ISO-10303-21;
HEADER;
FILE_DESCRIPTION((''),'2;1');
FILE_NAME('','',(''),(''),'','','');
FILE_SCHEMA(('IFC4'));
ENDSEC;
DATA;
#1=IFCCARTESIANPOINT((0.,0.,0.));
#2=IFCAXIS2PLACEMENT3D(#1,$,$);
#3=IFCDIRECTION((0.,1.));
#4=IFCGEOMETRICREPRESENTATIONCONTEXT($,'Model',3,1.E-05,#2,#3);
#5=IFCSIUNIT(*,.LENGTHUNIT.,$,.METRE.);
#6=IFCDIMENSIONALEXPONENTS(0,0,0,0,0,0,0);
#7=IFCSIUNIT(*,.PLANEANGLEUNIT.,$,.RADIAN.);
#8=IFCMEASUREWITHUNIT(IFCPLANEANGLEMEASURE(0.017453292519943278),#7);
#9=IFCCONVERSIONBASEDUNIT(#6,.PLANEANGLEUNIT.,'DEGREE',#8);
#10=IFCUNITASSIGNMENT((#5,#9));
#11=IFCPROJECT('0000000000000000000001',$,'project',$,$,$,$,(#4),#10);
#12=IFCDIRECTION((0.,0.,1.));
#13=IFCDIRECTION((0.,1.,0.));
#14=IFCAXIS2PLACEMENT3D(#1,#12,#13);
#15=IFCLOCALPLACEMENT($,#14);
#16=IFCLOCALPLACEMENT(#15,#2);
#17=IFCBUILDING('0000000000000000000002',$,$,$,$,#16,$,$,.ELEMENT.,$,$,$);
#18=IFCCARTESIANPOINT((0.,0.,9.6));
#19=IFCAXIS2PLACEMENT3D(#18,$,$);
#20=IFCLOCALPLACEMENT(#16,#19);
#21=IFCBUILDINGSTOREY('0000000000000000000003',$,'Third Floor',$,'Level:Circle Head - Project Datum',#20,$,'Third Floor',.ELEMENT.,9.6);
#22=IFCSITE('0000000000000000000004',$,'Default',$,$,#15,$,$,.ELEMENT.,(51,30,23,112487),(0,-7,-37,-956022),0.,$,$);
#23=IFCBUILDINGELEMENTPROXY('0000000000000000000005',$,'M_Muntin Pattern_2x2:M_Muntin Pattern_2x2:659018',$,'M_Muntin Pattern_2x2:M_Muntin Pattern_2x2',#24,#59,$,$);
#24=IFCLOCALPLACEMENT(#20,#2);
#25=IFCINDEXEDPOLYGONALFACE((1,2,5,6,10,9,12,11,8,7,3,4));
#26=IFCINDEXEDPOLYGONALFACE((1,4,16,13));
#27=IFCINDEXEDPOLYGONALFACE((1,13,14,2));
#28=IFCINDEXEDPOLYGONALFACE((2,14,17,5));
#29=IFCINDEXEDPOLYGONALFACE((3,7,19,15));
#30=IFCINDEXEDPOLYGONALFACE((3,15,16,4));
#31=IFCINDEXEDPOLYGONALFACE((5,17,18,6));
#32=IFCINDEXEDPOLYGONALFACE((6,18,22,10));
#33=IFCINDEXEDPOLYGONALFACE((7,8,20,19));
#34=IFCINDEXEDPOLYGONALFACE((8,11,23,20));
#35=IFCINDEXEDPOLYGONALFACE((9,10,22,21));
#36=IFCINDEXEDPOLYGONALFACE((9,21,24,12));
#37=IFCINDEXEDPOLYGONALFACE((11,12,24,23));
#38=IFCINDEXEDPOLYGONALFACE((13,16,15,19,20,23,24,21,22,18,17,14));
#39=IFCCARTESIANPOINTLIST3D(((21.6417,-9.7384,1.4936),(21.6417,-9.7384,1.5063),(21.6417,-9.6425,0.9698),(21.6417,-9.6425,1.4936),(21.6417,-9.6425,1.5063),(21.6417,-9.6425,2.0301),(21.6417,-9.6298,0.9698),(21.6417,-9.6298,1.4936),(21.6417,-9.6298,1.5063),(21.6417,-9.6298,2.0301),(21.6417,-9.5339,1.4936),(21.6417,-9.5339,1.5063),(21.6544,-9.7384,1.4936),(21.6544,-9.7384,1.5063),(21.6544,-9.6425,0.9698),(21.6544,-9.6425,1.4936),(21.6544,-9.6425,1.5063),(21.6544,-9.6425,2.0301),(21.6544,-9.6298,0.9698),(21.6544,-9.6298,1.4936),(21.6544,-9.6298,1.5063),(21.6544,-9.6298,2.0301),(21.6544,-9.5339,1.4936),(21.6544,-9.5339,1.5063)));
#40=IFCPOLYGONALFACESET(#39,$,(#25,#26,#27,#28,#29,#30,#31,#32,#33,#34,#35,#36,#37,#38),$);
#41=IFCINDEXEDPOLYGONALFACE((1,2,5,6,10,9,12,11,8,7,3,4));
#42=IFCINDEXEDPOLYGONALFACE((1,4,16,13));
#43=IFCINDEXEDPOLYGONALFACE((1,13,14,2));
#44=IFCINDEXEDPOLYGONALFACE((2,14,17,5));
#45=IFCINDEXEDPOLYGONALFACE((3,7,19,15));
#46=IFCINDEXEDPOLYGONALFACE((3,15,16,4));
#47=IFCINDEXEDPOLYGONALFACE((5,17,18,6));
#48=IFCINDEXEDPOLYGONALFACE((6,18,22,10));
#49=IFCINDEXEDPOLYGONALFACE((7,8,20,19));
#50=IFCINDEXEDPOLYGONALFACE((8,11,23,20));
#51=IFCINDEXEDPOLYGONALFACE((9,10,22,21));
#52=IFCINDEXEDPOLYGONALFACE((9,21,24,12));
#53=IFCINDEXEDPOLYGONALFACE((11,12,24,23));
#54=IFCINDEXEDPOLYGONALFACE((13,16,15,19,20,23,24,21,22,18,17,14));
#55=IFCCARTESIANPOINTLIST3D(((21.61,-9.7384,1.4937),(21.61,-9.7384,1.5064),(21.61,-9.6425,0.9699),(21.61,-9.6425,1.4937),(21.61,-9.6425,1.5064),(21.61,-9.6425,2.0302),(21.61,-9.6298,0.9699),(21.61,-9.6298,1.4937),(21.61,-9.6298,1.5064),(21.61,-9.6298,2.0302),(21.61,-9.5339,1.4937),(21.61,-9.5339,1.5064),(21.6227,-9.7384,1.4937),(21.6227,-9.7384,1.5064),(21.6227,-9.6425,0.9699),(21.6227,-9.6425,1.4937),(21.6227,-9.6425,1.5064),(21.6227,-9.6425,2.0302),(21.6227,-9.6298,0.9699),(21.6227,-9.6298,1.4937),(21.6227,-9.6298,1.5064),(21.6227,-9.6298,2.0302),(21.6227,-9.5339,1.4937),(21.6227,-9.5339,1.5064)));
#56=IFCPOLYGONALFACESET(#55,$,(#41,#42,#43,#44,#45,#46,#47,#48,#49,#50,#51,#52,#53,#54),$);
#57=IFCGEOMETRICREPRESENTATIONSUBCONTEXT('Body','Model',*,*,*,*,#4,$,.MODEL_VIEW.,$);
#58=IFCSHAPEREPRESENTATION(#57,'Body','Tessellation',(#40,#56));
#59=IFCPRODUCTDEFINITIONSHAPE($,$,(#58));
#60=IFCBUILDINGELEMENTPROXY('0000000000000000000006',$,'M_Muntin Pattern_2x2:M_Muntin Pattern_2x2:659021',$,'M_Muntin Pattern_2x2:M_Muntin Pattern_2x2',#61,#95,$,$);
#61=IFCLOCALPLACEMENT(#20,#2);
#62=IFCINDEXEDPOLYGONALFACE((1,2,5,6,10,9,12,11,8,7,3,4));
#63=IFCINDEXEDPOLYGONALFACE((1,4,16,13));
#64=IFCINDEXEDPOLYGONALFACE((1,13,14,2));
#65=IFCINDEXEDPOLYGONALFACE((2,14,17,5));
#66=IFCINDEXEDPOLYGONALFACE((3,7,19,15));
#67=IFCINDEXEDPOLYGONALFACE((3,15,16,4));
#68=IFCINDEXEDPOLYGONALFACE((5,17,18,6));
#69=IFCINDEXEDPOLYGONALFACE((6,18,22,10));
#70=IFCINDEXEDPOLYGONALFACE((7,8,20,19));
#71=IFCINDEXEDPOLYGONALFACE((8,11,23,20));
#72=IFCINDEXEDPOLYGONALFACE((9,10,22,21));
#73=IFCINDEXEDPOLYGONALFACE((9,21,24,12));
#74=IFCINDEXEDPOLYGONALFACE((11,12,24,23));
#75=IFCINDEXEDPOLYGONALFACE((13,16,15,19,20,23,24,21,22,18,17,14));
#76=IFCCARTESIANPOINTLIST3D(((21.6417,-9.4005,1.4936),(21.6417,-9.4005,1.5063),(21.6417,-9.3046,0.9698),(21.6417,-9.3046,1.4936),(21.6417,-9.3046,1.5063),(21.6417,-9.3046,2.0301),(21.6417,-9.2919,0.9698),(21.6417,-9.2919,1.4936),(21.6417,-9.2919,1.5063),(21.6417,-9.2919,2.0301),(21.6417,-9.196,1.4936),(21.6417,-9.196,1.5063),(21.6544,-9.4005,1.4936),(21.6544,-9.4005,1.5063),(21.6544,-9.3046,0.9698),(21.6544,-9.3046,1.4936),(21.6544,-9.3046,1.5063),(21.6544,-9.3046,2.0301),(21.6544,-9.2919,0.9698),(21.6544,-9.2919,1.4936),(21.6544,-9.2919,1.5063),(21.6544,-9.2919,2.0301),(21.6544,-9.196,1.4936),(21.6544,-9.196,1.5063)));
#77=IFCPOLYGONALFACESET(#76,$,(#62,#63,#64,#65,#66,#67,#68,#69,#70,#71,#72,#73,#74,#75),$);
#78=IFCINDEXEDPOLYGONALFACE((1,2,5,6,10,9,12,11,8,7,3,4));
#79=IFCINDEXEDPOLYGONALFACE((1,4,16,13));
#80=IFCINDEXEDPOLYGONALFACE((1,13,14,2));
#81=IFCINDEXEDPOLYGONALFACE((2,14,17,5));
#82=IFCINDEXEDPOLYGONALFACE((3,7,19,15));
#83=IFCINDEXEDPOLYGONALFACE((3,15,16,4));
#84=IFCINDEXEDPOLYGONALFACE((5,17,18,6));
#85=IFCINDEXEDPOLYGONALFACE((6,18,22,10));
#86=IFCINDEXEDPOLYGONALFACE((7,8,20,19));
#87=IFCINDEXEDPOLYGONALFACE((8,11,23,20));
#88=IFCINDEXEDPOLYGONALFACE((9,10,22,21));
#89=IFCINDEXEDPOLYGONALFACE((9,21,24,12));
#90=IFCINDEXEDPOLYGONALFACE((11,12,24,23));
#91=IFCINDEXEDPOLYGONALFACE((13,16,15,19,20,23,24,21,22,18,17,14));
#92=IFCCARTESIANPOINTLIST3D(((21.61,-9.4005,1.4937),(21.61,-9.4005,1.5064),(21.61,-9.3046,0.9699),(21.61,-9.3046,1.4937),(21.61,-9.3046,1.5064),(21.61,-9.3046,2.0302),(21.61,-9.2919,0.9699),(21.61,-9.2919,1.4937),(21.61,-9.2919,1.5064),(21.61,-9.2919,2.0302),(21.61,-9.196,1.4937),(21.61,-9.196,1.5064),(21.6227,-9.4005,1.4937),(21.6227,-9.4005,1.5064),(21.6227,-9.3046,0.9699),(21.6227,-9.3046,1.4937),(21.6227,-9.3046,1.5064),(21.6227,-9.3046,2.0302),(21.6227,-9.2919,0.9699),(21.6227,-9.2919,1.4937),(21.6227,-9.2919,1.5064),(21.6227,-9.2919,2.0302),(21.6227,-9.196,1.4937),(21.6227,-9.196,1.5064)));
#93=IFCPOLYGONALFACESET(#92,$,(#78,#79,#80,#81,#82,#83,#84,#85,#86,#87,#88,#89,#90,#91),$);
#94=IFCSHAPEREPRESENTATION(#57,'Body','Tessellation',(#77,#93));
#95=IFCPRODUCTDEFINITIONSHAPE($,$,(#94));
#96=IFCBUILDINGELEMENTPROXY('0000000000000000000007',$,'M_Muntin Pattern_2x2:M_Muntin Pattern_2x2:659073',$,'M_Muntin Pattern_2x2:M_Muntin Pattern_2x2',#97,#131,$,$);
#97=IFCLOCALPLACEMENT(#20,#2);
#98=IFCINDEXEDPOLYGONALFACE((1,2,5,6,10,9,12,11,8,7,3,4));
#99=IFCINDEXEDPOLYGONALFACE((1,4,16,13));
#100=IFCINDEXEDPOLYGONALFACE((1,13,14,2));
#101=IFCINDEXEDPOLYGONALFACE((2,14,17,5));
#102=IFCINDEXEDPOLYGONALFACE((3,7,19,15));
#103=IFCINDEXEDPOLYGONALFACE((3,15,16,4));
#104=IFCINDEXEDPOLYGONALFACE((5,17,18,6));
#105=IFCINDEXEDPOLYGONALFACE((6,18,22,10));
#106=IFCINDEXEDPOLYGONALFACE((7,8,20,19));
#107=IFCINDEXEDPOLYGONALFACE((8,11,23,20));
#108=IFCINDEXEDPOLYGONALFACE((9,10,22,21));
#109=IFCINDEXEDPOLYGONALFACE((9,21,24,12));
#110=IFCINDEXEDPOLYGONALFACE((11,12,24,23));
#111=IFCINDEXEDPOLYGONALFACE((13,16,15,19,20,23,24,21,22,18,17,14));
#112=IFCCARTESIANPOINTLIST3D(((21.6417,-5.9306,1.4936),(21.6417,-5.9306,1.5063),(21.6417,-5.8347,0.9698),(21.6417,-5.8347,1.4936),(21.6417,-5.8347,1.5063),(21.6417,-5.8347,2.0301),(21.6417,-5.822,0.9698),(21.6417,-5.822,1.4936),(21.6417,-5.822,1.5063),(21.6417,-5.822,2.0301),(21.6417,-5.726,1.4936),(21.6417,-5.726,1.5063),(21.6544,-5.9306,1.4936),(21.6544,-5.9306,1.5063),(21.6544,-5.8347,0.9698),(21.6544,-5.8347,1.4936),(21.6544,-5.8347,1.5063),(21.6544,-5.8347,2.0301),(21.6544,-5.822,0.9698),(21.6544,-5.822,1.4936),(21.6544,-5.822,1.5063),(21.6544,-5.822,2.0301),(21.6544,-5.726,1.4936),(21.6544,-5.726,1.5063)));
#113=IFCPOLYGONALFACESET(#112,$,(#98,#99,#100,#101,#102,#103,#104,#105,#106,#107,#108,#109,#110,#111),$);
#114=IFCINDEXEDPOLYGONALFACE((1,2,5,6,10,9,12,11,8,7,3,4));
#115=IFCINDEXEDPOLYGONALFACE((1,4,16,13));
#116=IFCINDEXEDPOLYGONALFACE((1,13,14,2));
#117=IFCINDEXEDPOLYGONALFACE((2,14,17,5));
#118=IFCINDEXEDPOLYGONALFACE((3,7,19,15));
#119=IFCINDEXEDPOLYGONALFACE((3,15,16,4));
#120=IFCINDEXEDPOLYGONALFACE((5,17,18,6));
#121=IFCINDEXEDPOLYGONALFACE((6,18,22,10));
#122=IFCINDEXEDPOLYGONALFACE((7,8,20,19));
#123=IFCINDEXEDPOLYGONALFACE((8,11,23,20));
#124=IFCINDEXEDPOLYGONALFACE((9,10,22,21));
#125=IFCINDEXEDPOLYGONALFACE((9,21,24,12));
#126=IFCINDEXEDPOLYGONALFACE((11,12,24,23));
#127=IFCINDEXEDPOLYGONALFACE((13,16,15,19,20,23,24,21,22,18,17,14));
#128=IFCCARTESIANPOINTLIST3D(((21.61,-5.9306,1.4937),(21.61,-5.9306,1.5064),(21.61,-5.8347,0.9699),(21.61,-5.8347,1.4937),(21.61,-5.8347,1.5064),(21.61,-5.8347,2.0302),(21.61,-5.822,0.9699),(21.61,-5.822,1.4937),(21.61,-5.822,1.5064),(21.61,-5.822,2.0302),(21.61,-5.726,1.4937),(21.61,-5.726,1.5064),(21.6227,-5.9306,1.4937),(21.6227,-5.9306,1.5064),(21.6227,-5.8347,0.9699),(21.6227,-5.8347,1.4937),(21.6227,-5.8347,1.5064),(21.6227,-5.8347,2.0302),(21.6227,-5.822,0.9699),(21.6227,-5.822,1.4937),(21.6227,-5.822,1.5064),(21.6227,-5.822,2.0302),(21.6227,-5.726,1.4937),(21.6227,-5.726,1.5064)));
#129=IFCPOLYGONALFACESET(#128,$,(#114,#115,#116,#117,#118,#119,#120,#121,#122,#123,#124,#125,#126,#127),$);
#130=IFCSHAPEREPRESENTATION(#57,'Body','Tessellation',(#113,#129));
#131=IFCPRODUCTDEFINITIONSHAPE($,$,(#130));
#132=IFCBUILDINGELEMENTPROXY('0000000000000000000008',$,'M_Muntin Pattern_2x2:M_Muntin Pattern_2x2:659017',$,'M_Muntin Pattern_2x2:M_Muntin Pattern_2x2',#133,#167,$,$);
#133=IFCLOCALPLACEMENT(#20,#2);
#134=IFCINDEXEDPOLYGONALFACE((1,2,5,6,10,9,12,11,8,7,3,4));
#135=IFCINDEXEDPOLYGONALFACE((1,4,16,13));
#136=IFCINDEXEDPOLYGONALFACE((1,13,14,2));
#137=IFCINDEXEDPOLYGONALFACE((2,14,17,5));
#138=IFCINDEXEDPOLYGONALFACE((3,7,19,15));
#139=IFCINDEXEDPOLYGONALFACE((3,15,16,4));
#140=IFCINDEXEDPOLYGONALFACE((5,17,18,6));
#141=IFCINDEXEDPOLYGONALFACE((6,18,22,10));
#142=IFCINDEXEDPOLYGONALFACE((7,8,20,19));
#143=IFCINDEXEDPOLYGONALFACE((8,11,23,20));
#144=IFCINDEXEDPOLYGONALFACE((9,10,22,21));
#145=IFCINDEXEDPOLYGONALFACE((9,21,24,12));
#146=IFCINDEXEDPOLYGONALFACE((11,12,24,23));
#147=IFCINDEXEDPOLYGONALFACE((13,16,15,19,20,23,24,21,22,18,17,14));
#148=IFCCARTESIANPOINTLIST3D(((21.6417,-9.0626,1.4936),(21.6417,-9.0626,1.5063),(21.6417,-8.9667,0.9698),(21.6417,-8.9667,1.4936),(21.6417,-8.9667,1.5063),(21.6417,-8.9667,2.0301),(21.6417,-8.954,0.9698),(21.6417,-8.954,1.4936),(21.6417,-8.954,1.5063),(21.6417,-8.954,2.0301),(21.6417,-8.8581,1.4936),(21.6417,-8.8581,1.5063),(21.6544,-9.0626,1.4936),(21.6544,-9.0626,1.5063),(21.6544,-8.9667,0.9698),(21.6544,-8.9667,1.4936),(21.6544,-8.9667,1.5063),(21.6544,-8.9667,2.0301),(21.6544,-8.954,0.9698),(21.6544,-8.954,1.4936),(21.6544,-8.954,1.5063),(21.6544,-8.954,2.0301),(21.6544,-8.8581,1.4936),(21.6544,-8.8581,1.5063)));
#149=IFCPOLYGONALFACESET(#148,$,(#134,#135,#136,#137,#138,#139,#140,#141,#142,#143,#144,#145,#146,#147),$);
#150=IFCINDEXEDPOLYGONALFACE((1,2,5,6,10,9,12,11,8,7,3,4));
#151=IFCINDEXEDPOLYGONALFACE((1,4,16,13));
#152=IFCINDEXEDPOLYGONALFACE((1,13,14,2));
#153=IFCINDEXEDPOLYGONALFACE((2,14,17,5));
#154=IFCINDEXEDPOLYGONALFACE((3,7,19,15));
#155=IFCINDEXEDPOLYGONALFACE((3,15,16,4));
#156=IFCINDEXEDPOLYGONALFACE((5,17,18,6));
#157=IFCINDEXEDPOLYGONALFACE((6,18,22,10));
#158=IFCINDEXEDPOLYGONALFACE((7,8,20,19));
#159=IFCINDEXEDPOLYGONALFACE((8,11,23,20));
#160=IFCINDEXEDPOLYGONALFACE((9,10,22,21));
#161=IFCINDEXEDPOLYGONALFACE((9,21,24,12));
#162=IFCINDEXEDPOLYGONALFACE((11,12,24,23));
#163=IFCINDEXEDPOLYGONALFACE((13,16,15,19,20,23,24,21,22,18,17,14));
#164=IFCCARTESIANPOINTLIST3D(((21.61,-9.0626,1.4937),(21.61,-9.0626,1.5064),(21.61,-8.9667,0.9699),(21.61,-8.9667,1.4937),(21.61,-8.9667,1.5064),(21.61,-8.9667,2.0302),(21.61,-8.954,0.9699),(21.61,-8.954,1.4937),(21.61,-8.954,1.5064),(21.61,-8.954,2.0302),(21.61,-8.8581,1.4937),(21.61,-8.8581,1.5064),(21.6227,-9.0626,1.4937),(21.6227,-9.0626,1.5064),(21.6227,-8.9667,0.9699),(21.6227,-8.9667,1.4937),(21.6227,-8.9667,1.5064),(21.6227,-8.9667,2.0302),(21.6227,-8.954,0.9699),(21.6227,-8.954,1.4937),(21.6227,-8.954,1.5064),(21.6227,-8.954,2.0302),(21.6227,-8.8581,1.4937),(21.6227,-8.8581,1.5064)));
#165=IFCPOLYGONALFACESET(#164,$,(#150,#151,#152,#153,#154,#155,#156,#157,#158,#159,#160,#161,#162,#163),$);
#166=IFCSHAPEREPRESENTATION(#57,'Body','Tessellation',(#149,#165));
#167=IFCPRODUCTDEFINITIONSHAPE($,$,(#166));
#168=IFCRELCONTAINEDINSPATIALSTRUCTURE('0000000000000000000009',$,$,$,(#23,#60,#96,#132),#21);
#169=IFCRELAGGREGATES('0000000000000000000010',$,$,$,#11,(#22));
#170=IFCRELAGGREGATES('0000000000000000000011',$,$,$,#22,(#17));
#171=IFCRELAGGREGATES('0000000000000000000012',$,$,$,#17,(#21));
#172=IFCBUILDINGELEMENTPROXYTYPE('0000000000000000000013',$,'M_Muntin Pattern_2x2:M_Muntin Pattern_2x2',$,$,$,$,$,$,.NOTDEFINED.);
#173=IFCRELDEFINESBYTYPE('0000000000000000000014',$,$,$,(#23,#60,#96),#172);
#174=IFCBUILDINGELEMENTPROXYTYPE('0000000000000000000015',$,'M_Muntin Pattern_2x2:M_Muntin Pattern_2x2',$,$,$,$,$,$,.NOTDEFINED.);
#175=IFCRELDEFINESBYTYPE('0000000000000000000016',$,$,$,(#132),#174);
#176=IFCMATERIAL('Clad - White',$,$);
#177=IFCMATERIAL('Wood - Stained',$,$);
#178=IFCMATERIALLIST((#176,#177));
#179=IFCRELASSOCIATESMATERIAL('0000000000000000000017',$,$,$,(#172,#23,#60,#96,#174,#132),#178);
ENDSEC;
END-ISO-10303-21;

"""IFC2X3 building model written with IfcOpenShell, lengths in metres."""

from ifc_helpers import new_model, entity, si_unit, converted_unit, direction, frame, origin, place, context, subcontext, project, spatial, polyline, outline, extrude, source, transform, mapped, material, material_list, type_object, type_shapes, element, save


model = new_model("IFC2X3")

# Units and contexts
model_context = context("Model", 3, precision=1e-05, world=origin(), true_north=direction((0.0, 1.0)))
body_context = subcontext(model_context, "Body", "Model", "MODEL_VIEW")
ifc_project = project(units=[si_unit("LENGTHUNIT", "METRE"), converted_unit("PLANEANGLEUNIT", "DEGREE", entity("IfcPlaneAngleMeasure", 0.017453292519943278), si_unit("PLANEANGLEUNIT", "RADIAN"), dimensions=[0, 0, 0, 0, 0, 0, 0])], contexts=[model_context])

# Site, building, storey
site_placement = place(None, frame((0.0, 0.0, 0.0), z_axis=(0.0, 0.0, 1.0), x_axis=(0.0, 1.0, 0.0)))
site = spatial("IfcSite", under=ifc_project, at=site_placement, Name="Default", CompositionType="ELEMENT", RefLatitude=(51, 30, 23, 112487), RefLongitude=(0, -7, -37, -956022), RefElevation=0.0)
building_placement = place(site_placement, origin())
building = spatial("IfcBuilding", under=site, at=building_placement, CompositionType="ELEMENT")
storey_placement = place(building_placement, frame((0.0, 0.0, 9.6)))
storey = spatial("IfcBuildingStorey", under=building, at=storey_placement, Name="Third Floor", ObjectType="Level:Circle Head - Project Datum", LongName="Third Floor", CompositionType="ELEMENT", Elevation=9.6)

# Building element proxies
ifc_material_1 = material(Name="Clad - White")
ifc_material_2 = material(Name="Wood - Stained")
ifc_material_list = material_list([ifc_material_1, ifc_material_2])
building_element_proxy_type_1 = type_object("IfcBuildingElementProxyType", Name="M_Muntin Pattern_2x2:M_Muntin Pattern_2x2", PredefinedType="NOTDEFINED", material=ifc_material_list)
shared_shape_1 = source(origin(), body_context, "Body", "SweptSolid", [
    extrude(outline(polyline([(0.0064, -0.0064), (0.5301, -0.0064), (0.5301, 0.0063), (0.0064, 0.0063), (0.0064, 0.1023), (-0.0063, 0.1023), (-0.0063, 0.0063), (-0.5302, 0.0063), (-0.5302, -0.0064), (-0.0063, -0.0064), (-0.0063, -0.1023), (0.0064, -0.1023), (0.0064, -0.0064)])), frame((0.0, -0.0222, 0.5301), z_axis=(0.0, 1.0, 0.0), x_axis=(0.0, 0.0, 1.0)), (0.0, 0.0, 1.0), 0.0127),
    extrude(outline(polyline([(0.0064, -0.0064), (0.5302, -0.0064), (0.5302, 0.0063), (0.0064, 0.0063), (0.0064, 0.1023), (-0.0063, 0.1023), (-0.0063, 0.0063), (-0.5302, 0.0063), (-0.5302, -0.0064), (-0.0063, -0.0064), (-0.0063, -0.1023), (0.0064, -0.1023), (0.0064, -0.0064)])), frame((0.0, 0.0095, 0.5302), z_axis=(0.0, 1.0, 0.0), x_axis=(0.0, 0.0, 1.0)), (0.0, 0.0, 1.0), 0.0127),
])
type_shapes(building_element_proxy_type_1, [shared_shape_1])
for number, where, z_axis, x_axis, name in (
    (1, (21.6322, -9.6361, 0.9699), (0.0, 0.0, 1.0), (0.0, 1.0, 0.0), "M_Muntin Pattern_2x2:M_Muntin Pattern_2x2:659018"),
    (2, (21.6322, -9.2983, 0.9699), (0.0, 0.0, 1.0), (0.0, 1.0, 0.0), "M_Muntin Pattern_2x2:M_Muntin Pattern_2x2:659021"),
    (3, (21.6322, -5.8283, 0.9699), (0.0, 0.0, 1.0), (0.0, 1.0, 0.0), "M_Muntin Pattern_2x2:M_Muntin Pattern_2x2:659073"),
):
    element("IfcBuildingElementProxy", number, at=place(storey_placement, frame(where, z_axis=z_axis, x_axis=x_axis)), inside=storey, type_object=building_element_proxy_type_1, material=ifc_material_list, Name=name, ObjectType="M_Muntin Pattern_2x2:M_Muntin Pattern_2x2", context=body_context, shape_type="MappedRepresentation", body=[
        mapped(shared_shape_1, transform((0.0, 0.0, 0.0), scale=1.0)),
    ])
building_element_proxy_type_2 = type_object("IfcBuildingElementProxyType", Name="M_Muntin Pattern_2x2:M_Muntin Pattern_2x2", PredefinedType="NOTDEFINED", material=ifc_material_list)
shared_shape_2 = source(origin(), body_context, "Body", "SweptSolid", [
    extrude(outline(polyline([(0.0064, -0.0064), (0.5301, -0.0064), (0.5301, 0.0063), (0.0064, 0.0063), (0.0064, 0.1023), (-0.0063, 0.1023), (-0.0063, 0.0063), (-0.5302, 0.0063), (-0.5302, -0.0064), (-0.0063, -0.0064), (-0.0063, -0.1023), (0.0064, -0.1023), (0.0064, -0.0064)])), frame((0.0, 0.0095, 0.5301), z_axis=(0.0, 1.0, 0.0), x_axis=(0.0, 0.0, 1.0)), (0.0, 0.0, 1.0), 0.0127),
    extrude(outline(polyline([(0.0064, -0.0064), (0.5302, -0.0064), (0.5302, 0.0063), (0.0064, 0.0063), (0.0064, 0.1023), (-0.0063, 0.1023), (-0.0063, 0.0063), (-0.5302, 0.0063), (-0.5302, -0.0064), (-0.0063, -0.0064), (-0.0063, -0.1023), (0.0064, -0.1023), (0.0064, -0.0064)])), frame((0.0, -0.0222, 0.5302), z_axis=(0.0, 1.0, 0.0), x_axis=(0.0, 0.0, 1.0)), (0.0, 0.0, 1.0), 0.0127),
])
type_shapes(building_element_proxy_type_2, [shared_shape_2])
proxy_placement = place(storey_placement, frame((21.6322, -8.9604, 0.9699), z_axis=(0.0, 0.0, 1.0), x_axis=(0.0, -1.0, 0.0)))
element("IfcBuildingElementProxy", 4, at=proxy_placement, inside=storey, type_object=building_element_proxy_type_2, material=ifc_material_list, Name="M_Muntin Pattern_2x2:M_Muntin Pattern_2x2:659017", ObjectType="M_Muntin Pattern_2x2:M_Muntin Pattern_2x2", context=body_context, shape_type="MappedRepresentation", body=[
    mapped(shared_shape_2, transform((0.0, 0.0, 0.0), scale=1.0)),
])

save(model, "model.ifc")
